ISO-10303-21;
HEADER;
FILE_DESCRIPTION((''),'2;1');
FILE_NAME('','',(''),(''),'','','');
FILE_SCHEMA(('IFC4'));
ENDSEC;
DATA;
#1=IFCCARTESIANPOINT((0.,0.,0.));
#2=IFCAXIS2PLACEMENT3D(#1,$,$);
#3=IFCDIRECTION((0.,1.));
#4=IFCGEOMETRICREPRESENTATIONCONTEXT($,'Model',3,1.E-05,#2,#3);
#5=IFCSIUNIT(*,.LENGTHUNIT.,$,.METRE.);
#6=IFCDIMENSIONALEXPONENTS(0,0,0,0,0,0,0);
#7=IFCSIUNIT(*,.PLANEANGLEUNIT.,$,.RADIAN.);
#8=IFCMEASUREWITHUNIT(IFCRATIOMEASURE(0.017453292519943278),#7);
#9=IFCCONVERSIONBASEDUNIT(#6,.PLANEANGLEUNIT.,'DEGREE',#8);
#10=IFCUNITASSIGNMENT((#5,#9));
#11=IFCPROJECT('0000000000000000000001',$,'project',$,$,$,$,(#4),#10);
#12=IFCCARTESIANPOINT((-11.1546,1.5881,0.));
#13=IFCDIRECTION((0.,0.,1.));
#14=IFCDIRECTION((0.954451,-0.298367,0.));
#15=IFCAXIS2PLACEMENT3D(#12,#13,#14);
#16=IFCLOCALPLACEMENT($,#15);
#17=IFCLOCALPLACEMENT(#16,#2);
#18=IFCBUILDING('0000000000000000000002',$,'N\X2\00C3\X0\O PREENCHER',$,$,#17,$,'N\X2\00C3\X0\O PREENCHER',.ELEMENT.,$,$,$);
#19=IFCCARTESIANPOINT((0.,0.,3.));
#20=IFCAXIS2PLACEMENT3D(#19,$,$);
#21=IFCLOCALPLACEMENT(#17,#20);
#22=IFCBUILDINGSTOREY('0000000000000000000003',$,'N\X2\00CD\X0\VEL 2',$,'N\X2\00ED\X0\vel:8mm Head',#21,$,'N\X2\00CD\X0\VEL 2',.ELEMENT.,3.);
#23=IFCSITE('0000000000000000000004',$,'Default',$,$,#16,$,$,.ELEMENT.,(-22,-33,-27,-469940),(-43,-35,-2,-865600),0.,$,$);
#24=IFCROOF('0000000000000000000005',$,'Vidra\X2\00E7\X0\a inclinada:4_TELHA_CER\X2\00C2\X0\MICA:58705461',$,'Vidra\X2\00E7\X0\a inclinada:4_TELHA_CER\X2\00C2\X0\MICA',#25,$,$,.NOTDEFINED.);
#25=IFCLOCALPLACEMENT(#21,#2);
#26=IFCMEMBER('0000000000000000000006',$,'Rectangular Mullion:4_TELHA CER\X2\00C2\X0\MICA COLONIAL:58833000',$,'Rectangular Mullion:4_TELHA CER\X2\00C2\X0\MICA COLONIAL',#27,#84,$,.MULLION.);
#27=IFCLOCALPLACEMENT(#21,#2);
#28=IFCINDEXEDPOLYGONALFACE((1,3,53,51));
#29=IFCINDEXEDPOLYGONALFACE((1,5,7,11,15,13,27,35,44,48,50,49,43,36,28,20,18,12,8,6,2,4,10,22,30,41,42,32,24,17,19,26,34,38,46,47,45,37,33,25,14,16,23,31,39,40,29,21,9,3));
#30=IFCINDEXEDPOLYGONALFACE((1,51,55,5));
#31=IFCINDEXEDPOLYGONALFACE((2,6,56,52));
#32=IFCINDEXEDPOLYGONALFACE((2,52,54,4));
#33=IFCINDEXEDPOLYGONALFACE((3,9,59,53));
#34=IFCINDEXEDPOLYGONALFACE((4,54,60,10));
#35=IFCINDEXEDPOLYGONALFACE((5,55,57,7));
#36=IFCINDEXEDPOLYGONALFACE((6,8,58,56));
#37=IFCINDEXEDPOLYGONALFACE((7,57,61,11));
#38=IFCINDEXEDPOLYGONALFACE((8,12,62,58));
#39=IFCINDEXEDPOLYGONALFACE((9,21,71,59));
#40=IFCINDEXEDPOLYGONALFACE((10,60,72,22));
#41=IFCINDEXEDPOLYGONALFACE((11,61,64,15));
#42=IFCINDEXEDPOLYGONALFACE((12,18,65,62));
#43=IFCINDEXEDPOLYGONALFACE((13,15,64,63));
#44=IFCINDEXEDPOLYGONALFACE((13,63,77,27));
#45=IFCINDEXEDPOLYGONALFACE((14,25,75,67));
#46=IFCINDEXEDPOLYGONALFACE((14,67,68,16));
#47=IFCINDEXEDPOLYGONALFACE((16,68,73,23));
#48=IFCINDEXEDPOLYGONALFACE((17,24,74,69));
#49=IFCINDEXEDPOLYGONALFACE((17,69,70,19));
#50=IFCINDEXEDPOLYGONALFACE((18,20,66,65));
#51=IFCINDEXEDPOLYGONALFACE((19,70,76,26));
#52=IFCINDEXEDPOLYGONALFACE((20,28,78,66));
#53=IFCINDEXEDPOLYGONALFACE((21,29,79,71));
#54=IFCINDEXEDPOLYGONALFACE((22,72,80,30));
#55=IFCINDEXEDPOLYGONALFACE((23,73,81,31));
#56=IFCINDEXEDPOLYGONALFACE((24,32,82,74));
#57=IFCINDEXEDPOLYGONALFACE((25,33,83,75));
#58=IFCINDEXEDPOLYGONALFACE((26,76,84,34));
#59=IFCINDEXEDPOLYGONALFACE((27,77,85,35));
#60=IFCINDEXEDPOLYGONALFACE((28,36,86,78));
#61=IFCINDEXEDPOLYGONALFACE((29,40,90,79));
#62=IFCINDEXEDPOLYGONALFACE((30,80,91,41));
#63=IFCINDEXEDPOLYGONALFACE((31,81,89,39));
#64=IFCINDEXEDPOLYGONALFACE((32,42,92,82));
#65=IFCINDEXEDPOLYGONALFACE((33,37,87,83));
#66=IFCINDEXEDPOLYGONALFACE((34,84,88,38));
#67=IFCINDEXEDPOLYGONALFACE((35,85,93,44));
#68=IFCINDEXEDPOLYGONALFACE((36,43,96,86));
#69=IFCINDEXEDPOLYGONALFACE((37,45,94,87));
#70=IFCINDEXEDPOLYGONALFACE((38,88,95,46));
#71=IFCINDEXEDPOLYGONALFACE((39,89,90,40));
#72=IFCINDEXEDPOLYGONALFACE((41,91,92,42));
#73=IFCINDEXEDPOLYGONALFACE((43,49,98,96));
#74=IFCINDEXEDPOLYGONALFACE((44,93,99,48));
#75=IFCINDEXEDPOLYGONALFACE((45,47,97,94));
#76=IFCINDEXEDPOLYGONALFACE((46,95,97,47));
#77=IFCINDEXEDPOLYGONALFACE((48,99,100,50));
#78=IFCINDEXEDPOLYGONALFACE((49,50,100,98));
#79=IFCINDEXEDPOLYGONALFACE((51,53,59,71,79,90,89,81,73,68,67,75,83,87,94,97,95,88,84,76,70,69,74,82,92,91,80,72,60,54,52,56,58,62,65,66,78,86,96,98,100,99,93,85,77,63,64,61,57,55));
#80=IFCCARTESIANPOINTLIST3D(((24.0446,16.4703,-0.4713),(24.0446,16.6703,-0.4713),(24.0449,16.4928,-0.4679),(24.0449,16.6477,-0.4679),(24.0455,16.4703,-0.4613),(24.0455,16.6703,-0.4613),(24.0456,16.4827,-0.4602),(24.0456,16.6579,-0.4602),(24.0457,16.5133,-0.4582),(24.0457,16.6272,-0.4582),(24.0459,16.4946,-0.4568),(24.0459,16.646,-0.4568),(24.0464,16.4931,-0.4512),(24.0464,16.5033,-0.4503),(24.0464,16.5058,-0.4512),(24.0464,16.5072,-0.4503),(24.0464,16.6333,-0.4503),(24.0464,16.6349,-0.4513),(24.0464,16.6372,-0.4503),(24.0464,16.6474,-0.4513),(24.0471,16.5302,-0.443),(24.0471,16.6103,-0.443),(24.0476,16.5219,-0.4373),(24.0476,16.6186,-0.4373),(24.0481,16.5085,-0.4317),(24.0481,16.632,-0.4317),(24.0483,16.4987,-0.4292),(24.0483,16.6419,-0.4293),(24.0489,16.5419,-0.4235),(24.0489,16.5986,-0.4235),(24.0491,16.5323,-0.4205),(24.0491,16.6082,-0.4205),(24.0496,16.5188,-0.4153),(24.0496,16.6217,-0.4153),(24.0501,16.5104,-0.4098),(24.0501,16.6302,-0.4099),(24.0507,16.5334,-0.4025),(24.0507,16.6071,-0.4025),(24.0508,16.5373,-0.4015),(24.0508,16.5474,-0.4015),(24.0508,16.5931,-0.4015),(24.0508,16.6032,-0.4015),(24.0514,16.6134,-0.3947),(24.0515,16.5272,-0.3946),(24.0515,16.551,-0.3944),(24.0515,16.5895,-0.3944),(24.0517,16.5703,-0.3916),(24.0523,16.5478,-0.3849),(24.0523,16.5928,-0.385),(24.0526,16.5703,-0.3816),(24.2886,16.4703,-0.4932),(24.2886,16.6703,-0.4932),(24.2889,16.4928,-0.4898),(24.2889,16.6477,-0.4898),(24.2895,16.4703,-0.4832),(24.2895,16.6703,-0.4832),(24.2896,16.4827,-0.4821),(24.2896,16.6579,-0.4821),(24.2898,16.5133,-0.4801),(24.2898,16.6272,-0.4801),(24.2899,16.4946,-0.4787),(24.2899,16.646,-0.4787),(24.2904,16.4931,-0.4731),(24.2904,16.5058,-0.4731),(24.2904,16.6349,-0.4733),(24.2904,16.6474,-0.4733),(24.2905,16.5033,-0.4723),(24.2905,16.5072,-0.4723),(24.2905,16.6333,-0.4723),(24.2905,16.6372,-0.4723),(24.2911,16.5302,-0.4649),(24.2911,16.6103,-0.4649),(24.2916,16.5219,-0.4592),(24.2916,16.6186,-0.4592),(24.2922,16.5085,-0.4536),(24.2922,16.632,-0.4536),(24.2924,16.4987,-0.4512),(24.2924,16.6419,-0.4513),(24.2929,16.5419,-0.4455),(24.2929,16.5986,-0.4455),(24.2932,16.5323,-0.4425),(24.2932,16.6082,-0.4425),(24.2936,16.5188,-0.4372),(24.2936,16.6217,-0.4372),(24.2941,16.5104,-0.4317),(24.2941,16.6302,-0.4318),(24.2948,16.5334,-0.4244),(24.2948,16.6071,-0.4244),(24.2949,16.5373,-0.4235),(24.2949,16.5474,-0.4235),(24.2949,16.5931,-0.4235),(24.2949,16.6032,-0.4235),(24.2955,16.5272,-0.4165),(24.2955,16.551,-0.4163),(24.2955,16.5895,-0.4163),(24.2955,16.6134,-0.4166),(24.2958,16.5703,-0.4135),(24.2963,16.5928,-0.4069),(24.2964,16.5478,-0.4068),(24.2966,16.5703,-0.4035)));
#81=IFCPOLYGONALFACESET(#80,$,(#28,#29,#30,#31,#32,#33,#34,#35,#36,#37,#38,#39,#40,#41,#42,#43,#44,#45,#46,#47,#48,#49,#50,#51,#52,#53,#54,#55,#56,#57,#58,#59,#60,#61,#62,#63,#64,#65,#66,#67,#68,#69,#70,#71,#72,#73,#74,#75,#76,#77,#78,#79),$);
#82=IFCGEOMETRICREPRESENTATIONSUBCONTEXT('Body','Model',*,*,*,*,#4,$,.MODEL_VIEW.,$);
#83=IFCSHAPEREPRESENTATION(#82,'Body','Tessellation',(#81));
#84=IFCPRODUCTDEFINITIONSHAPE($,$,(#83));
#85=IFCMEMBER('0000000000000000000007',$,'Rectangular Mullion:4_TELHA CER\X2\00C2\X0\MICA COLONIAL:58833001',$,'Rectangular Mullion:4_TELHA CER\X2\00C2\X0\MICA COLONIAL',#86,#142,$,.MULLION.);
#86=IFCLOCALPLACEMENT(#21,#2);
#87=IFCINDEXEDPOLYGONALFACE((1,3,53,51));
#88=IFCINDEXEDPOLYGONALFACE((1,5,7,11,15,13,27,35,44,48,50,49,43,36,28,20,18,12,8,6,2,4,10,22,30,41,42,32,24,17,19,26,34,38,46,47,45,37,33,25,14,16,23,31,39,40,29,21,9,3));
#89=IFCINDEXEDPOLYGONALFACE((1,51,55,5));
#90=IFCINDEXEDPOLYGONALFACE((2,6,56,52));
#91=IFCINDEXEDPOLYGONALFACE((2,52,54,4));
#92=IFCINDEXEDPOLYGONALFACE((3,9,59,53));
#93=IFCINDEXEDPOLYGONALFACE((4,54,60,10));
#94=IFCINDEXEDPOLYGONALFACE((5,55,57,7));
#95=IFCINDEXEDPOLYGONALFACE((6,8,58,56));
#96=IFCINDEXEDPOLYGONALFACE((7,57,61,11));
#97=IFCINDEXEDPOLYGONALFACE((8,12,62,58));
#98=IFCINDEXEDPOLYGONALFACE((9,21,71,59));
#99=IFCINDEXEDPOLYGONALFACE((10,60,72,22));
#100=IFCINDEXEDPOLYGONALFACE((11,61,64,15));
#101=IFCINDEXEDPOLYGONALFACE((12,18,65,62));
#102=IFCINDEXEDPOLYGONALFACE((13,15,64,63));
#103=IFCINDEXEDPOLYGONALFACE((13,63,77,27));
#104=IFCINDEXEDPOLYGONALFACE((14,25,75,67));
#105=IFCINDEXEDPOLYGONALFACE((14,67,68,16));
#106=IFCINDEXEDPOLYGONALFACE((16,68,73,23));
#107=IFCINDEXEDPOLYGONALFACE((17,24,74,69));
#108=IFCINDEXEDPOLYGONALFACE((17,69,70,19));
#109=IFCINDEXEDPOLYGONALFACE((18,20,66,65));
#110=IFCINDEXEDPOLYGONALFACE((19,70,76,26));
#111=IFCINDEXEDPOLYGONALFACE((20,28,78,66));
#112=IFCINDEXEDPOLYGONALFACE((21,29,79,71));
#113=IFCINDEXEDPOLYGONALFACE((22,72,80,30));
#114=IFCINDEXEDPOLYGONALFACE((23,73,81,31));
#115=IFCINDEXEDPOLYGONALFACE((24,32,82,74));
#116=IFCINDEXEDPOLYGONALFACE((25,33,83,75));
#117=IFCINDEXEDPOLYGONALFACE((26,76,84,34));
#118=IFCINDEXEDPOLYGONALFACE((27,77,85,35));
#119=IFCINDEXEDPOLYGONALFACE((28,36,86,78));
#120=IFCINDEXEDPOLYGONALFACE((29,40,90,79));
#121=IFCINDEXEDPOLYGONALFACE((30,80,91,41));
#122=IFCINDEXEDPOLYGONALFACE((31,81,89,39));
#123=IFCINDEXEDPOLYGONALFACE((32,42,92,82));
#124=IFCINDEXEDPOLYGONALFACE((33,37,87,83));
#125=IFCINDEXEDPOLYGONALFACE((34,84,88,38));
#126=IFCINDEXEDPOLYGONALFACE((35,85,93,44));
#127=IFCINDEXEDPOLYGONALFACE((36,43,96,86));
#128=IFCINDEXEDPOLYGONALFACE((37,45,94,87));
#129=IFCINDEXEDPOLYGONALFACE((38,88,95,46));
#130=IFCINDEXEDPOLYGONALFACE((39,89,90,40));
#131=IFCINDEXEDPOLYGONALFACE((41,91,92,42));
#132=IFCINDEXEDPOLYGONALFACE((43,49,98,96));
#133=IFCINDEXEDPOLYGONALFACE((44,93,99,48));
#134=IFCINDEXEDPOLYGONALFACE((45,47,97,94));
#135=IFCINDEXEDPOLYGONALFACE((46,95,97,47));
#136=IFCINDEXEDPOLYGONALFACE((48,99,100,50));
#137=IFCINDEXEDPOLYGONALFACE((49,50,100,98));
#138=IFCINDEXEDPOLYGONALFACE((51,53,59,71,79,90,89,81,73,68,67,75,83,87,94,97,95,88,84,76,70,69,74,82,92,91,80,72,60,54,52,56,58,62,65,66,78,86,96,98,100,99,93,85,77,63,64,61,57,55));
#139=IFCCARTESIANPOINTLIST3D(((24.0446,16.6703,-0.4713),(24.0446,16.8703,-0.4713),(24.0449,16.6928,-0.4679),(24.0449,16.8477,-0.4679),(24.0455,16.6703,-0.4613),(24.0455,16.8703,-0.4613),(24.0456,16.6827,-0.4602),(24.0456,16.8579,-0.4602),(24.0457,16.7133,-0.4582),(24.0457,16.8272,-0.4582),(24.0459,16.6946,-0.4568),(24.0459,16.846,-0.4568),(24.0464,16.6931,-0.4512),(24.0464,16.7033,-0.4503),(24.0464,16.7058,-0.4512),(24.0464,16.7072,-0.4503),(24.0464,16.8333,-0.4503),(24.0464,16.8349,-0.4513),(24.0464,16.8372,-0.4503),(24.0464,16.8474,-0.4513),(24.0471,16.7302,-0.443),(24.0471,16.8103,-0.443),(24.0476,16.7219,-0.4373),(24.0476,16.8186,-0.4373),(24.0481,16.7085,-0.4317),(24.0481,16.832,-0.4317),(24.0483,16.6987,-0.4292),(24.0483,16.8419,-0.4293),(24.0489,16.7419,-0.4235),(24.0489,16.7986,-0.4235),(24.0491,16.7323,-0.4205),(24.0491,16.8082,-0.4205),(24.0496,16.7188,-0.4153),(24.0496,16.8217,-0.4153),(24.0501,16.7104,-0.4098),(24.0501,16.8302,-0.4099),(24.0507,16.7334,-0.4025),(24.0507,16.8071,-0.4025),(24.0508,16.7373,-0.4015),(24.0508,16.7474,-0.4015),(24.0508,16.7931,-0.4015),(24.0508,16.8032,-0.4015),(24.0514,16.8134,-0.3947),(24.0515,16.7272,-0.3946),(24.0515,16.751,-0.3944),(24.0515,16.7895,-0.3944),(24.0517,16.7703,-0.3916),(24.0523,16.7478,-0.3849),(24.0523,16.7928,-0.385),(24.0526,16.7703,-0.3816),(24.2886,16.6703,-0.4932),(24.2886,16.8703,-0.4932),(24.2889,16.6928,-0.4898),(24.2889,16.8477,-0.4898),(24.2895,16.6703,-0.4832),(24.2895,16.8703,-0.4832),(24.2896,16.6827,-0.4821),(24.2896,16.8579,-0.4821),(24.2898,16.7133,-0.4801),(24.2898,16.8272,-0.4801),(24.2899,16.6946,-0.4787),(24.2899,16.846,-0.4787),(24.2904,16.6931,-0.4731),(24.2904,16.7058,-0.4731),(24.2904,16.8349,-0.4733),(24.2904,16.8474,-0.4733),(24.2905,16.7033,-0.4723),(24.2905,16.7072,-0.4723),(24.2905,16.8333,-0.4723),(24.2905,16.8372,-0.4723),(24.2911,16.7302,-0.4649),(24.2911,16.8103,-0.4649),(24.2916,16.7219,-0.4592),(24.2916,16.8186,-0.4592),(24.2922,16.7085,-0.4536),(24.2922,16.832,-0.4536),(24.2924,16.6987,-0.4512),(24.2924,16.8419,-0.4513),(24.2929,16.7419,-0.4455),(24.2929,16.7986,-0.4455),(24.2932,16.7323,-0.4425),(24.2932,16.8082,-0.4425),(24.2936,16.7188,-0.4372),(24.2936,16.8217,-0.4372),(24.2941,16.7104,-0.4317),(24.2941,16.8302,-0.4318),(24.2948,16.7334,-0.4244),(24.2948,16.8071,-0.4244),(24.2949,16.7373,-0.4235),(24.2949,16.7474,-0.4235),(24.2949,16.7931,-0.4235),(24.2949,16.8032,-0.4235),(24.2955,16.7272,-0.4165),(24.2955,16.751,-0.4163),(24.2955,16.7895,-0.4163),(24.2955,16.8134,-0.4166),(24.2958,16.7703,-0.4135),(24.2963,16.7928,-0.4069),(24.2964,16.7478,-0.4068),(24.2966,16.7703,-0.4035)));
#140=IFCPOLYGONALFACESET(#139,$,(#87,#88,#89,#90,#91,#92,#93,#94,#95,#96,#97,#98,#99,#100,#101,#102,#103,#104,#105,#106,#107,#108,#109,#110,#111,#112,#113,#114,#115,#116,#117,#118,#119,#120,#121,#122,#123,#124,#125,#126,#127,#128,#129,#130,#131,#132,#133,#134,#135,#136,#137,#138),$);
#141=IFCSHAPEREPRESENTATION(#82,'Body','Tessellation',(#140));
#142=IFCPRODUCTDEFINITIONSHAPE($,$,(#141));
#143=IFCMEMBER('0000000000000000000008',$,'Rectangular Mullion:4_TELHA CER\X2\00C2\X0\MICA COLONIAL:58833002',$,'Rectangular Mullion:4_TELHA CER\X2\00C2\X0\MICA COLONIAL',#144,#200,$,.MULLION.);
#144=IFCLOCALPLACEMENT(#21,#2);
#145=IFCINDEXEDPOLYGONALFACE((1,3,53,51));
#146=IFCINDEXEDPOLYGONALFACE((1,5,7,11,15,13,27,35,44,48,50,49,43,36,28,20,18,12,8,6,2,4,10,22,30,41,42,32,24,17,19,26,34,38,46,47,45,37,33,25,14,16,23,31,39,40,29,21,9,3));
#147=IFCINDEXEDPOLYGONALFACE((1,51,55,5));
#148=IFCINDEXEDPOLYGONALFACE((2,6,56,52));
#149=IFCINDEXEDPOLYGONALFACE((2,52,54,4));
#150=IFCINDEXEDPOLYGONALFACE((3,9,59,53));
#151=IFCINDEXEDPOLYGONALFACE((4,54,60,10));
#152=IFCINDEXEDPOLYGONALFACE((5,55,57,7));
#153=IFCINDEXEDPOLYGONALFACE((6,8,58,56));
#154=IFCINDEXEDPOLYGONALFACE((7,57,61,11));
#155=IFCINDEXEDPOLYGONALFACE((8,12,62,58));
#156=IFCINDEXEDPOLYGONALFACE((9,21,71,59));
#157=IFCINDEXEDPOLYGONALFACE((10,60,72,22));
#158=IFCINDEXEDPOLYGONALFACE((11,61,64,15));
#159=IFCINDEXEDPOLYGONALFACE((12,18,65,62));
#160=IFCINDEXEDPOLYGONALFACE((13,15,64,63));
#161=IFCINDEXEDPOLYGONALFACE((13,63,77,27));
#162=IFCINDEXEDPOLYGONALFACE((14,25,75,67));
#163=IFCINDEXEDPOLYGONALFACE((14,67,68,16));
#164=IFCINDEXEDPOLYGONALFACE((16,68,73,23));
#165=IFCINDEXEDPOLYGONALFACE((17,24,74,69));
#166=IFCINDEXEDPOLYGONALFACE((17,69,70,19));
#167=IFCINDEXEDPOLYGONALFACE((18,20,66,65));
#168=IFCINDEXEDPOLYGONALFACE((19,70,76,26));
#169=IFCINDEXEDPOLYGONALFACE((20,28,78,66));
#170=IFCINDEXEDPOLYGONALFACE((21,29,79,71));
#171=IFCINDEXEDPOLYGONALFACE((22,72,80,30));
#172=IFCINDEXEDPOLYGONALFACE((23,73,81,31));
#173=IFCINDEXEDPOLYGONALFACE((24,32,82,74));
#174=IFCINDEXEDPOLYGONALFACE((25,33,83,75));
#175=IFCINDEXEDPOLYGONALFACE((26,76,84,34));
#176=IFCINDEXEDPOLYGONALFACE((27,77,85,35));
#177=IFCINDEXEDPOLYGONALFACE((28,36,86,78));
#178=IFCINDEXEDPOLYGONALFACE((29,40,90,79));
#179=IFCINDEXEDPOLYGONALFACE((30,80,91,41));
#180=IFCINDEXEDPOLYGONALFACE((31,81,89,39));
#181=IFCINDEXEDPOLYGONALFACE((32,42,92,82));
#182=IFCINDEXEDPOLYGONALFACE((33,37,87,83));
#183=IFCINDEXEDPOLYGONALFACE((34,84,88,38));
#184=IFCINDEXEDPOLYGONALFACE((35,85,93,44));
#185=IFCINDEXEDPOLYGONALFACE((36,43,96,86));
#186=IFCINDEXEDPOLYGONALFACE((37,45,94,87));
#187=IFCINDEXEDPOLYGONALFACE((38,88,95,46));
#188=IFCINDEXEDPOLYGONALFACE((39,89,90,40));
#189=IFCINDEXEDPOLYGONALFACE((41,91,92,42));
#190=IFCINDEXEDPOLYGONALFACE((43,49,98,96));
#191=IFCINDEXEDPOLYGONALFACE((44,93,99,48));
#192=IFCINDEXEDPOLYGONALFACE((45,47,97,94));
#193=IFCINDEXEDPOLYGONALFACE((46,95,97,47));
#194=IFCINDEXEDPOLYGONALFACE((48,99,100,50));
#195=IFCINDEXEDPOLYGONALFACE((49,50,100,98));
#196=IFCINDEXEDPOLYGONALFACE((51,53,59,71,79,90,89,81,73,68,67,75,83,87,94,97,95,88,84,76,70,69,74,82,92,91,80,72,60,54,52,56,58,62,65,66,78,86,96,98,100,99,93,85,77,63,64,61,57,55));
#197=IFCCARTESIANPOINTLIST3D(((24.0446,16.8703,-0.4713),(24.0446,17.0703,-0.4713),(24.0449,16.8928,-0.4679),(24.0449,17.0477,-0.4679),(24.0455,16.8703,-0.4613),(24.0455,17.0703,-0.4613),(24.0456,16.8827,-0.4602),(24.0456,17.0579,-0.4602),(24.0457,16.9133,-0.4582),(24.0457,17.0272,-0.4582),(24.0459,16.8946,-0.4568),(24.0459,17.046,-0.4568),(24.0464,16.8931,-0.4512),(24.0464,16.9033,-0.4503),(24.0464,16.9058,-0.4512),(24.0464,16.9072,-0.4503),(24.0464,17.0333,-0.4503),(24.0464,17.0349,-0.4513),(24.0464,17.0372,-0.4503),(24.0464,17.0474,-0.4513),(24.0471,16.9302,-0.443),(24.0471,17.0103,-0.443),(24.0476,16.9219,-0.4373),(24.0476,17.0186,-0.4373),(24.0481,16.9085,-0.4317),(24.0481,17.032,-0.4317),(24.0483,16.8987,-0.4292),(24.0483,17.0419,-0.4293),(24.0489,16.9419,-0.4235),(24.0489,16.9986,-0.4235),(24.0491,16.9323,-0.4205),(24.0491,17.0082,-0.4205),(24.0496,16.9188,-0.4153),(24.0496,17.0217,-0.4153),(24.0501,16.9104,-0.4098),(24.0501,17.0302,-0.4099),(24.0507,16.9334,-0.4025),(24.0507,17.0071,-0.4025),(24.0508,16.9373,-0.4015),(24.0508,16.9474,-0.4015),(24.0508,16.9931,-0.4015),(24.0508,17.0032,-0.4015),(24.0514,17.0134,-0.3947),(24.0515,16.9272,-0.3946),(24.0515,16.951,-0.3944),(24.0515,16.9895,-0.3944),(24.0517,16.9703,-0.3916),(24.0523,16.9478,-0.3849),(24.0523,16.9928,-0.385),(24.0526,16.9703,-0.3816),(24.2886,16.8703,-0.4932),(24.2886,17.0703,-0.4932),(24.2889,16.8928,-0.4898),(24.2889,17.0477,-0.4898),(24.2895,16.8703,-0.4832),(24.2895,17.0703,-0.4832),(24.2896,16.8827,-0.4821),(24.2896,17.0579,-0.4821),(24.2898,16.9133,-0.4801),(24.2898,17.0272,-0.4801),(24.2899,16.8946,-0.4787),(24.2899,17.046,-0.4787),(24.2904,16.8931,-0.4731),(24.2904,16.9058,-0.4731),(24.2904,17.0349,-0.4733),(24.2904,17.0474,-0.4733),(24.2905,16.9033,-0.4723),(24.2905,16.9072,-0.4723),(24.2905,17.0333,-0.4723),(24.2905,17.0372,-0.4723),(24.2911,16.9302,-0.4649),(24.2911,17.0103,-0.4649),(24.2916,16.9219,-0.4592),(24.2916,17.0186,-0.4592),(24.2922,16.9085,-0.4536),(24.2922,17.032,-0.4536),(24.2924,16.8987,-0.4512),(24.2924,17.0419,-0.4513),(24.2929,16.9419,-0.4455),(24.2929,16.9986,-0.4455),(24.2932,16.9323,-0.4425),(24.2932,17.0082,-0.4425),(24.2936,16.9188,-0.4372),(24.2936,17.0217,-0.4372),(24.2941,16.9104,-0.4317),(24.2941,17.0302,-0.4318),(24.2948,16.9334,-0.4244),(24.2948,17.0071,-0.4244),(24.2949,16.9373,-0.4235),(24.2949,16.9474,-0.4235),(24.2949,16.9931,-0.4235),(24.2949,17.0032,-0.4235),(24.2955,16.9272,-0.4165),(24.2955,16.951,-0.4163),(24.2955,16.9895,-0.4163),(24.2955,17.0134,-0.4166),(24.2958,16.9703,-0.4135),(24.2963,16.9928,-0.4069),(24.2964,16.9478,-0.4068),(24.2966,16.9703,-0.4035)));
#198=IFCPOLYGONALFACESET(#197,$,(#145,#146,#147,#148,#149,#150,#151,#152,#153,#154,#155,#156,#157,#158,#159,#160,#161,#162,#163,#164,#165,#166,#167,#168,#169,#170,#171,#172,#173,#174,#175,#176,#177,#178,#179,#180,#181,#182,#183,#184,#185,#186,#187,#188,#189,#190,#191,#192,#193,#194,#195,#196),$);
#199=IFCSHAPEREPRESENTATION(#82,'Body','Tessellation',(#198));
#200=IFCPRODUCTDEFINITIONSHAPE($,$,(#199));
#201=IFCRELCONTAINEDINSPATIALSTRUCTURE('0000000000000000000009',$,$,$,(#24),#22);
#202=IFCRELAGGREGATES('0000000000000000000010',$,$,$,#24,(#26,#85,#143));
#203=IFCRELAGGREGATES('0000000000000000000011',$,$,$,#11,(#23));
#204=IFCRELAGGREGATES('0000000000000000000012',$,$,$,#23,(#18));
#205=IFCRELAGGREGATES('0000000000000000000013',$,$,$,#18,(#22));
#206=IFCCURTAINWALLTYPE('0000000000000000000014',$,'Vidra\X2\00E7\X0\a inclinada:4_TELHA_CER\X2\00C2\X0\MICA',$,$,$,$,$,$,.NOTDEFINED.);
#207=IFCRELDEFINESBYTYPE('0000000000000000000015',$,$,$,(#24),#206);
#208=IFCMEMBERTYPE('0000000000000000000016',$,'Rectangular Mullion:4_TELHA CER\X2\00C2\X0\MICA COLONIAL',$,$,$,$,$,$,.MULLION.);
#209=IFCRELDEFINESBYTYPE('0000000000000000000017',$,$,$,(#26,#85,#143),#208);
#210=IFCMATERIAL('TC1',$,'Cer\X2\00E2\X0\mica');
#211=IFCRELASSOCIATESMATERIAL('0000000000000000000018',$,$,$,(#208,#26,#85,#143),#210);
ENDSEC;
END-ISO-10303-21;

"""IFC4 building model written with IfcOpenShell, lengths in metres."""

from ifc_helpers import new_model, entity, si_unit, converted_unit, direction, frame, origin, place, context, subcontext, project, spatial, line, arc, indexed_curve, outline, extrude, source, transform, mapped, material, type_object, type_shapes, element, aggregate, save


model = new_model("IFC4")

# Units and contexts
model_context = context("Model", 3, precision=1e-05, world=origin(), true_north=direction((0.0, 1.0)))
body_context = subcontext(model_context, "Body", "Model", "MODEL_VIEW")
ifc_project = project(units=[si_unit("LENGTHUNIT", "METRE"), converted_unit("PLANEANGLEUNIT", "DEGREE", entity("IfcRatioMeasure", 0.017453292519943278), si_unit("PLANEANGLEUNIT", "RADIAN"), dimensions=[0, 0, 0, 0, 0, 0, 0])], contexts=[model_context])

# Site, building, storey
site_placement = place(None, frame((-11.1546, 1.5881, 0.0), z_axis=(0.0, 0.0, 1.0), x_axis=(0.954451, -0.298367, 0.0)))
site = spatial("IfcSite", under=ifc_project, at=site_placement, Name="Default", CompositionType="ELEMENT", RefLatitude=(-22, -33, -27, -469940), RefLongitude=(-43, -35, -2, -865600), RefElevation=0.0)
building_placement = place(site_placement, origin())
building = spatial("IfcBuilding", under=site, at=building_placement, Name="NÃO PREENCHER", LongName="NÃO PREENCHER", CompositionType="ELEMENT")
storey_placement = place(building_placement, frame((0.0, 0.0, 3.0)))
storey = spatial("IfcBuildingStorey", under=building, at=storey_placement, Name="NÍVEL 2", ObjectType="Nível:8mm Head", LongName="NÍVEL 2", CompositionType="ELEMENT", Elevation=3.0)

# Roof, members
curtain_wall_type = type_object("IfcCurtainWallType", Name="Vidraça inclinada:4_TELHA_CERÂMICA", PredefinedType="NOTDEFINED")
roof_placement = place(storey_placement, frame((0.0, 0.0, -3.0)))
roof = element("IfcRoof", 1, at=roof_placement, inside=storey, type_object=curtain_wall_type, Name="Vidraça inclinada:4_TELHA_CERÂMICA:58705461", ObjectType="Vidraça inclinada:4_TELHA_CERÂMICA", PredefinedType="NOTDEFINED")
ifc_material_1 = material(Name="TC1", Category="Cerâmica")
member_type_1 = type_object("IfcMemberType", Name="Rectangular Mullion:4_TELHA CERÂMICA COLONIAL", PredefinedType="MULLION", material=ifc_material_1)
shared_shape_1 = source(origin(), body_context, "Body", "SweptSolid", [
    extrude(outline(indexed_curve([(-0.029, -0.1), (-0.019, -0.1), (-0.0164, -0.0815), (-0.0089, -0.0645), (-0.0089, -0.0771), (0.061, 0.0), (-0.009, 0.0771), (-0.009, 0.0646), (-0.0165, 0.0816), (-0.019, 0.1), (-0.029, 0.1), (-0.0089, 0.0479), (0.041, 0.0229), (0.041, 0.0329), (0.0131, 0.0425), (-0.008, 0.0631), (-0.008, 0.067), (0.051, 0.0), (-0.008, -0.067), (-0.008, -0.0631), (0.0131, -0.0425), (0.041, -0.0329), (0.041, -0.0229), (-0.0089, -0.0479)], segments=[line(1, 2), arc(2, 3, 4), line(4, 5), arc(5, 6, 7), line(7, 8), arc(8, 9, 10), line(10, 11), arc(11, 12, 13), line(13, 14), arc(14, 15, 16), line(16, 17), arc(17, 18, 19), line(19, 20), arc(20, 21, 22), line(22, 23), arc(23, 24, 1)], self_intersect=False)), frame((0.0, -0.029, -0.245), z_axis=(0.0, 0.0, 1.0), x_axis=(0.0, -1.0, 0.0)), (0.0, 0.0, 1.0), 0.245),
])
type_shapes(member_type_1, [shared_shape_1])
member_1_placement = place(roof_placement, frame((24.0446, 16.5703, 2.5287), z_axis=(-0.99599, 0.0, 0.089469), x_axis=(0.0, 1.0, 0.0)))
member_1 = element("IfcMember", 2, at=member_1_placement, type_object=member_type_1, material=ifc_material_1, Name="Rectangular Mullion:4_TELHA CERÂMICA COLONIAL:58833000", ObjectType="Rectangular Mullion:4_TELHA CERÂMICA COLONIAL", PredefinedType="MULLION", context=body_context, shape_type="MappedRepresentation", body=[
    mapped(shared_shape_1, transform((0.0, 0.0, 0.0), scale=1.0)),
])
member_2_placement = place(roof_placement, frame((24.0446, 16.7703, 2.5287), z_axis=(-0.99599, 0.0, 0.089469), x_axis=(0.0, 1.0, 0.0)))
member_2 = element("IfcMember", 3, at=member_2_placement, type_object=member_type_1, material=ifc_material_1, Name="Rectangular Mullion:4_TELHA CERÂMICA COLONIAL:58833001", ObjectType="Rectangular Mullion:4_TELHA CERÂMICA COLONIAL", PredefinedType="MULLION", context=body_context, shape_type="MappedRepresentation", body=[
    mapped(shared_shape_1, transform((0.0, 0.0, 0.0), scale=1.0)),
])
member_3_placement = place(roof_placement, frame((24.0446, 16.9703, 2.5287), z_axis=(-0.99599, 0.0, 0.089469), x_axis=(0.0, 1.0, 0.0)))
member_3 = element("IfcMember", 4, at=member_3_placement, type_object=member_type_1, material=ifc_material_1, Name="Rectangular Mullion:4_TELHA CERÂMICA COLONIAL:58833002", ObjectType="Rectangular Mullion:4_TELHA CERÂMICA COLONIAL", PredefinedType="MULLION", context=body_context, shape_type="MappedRepresentation", body=[
    mapped(shared_shape_1, transform((0.0, 0.0, 0.0), scale=1.0)),
])
aggregate(roof, [member_1, member_2, member_3])

save(model, "model.ifc")
